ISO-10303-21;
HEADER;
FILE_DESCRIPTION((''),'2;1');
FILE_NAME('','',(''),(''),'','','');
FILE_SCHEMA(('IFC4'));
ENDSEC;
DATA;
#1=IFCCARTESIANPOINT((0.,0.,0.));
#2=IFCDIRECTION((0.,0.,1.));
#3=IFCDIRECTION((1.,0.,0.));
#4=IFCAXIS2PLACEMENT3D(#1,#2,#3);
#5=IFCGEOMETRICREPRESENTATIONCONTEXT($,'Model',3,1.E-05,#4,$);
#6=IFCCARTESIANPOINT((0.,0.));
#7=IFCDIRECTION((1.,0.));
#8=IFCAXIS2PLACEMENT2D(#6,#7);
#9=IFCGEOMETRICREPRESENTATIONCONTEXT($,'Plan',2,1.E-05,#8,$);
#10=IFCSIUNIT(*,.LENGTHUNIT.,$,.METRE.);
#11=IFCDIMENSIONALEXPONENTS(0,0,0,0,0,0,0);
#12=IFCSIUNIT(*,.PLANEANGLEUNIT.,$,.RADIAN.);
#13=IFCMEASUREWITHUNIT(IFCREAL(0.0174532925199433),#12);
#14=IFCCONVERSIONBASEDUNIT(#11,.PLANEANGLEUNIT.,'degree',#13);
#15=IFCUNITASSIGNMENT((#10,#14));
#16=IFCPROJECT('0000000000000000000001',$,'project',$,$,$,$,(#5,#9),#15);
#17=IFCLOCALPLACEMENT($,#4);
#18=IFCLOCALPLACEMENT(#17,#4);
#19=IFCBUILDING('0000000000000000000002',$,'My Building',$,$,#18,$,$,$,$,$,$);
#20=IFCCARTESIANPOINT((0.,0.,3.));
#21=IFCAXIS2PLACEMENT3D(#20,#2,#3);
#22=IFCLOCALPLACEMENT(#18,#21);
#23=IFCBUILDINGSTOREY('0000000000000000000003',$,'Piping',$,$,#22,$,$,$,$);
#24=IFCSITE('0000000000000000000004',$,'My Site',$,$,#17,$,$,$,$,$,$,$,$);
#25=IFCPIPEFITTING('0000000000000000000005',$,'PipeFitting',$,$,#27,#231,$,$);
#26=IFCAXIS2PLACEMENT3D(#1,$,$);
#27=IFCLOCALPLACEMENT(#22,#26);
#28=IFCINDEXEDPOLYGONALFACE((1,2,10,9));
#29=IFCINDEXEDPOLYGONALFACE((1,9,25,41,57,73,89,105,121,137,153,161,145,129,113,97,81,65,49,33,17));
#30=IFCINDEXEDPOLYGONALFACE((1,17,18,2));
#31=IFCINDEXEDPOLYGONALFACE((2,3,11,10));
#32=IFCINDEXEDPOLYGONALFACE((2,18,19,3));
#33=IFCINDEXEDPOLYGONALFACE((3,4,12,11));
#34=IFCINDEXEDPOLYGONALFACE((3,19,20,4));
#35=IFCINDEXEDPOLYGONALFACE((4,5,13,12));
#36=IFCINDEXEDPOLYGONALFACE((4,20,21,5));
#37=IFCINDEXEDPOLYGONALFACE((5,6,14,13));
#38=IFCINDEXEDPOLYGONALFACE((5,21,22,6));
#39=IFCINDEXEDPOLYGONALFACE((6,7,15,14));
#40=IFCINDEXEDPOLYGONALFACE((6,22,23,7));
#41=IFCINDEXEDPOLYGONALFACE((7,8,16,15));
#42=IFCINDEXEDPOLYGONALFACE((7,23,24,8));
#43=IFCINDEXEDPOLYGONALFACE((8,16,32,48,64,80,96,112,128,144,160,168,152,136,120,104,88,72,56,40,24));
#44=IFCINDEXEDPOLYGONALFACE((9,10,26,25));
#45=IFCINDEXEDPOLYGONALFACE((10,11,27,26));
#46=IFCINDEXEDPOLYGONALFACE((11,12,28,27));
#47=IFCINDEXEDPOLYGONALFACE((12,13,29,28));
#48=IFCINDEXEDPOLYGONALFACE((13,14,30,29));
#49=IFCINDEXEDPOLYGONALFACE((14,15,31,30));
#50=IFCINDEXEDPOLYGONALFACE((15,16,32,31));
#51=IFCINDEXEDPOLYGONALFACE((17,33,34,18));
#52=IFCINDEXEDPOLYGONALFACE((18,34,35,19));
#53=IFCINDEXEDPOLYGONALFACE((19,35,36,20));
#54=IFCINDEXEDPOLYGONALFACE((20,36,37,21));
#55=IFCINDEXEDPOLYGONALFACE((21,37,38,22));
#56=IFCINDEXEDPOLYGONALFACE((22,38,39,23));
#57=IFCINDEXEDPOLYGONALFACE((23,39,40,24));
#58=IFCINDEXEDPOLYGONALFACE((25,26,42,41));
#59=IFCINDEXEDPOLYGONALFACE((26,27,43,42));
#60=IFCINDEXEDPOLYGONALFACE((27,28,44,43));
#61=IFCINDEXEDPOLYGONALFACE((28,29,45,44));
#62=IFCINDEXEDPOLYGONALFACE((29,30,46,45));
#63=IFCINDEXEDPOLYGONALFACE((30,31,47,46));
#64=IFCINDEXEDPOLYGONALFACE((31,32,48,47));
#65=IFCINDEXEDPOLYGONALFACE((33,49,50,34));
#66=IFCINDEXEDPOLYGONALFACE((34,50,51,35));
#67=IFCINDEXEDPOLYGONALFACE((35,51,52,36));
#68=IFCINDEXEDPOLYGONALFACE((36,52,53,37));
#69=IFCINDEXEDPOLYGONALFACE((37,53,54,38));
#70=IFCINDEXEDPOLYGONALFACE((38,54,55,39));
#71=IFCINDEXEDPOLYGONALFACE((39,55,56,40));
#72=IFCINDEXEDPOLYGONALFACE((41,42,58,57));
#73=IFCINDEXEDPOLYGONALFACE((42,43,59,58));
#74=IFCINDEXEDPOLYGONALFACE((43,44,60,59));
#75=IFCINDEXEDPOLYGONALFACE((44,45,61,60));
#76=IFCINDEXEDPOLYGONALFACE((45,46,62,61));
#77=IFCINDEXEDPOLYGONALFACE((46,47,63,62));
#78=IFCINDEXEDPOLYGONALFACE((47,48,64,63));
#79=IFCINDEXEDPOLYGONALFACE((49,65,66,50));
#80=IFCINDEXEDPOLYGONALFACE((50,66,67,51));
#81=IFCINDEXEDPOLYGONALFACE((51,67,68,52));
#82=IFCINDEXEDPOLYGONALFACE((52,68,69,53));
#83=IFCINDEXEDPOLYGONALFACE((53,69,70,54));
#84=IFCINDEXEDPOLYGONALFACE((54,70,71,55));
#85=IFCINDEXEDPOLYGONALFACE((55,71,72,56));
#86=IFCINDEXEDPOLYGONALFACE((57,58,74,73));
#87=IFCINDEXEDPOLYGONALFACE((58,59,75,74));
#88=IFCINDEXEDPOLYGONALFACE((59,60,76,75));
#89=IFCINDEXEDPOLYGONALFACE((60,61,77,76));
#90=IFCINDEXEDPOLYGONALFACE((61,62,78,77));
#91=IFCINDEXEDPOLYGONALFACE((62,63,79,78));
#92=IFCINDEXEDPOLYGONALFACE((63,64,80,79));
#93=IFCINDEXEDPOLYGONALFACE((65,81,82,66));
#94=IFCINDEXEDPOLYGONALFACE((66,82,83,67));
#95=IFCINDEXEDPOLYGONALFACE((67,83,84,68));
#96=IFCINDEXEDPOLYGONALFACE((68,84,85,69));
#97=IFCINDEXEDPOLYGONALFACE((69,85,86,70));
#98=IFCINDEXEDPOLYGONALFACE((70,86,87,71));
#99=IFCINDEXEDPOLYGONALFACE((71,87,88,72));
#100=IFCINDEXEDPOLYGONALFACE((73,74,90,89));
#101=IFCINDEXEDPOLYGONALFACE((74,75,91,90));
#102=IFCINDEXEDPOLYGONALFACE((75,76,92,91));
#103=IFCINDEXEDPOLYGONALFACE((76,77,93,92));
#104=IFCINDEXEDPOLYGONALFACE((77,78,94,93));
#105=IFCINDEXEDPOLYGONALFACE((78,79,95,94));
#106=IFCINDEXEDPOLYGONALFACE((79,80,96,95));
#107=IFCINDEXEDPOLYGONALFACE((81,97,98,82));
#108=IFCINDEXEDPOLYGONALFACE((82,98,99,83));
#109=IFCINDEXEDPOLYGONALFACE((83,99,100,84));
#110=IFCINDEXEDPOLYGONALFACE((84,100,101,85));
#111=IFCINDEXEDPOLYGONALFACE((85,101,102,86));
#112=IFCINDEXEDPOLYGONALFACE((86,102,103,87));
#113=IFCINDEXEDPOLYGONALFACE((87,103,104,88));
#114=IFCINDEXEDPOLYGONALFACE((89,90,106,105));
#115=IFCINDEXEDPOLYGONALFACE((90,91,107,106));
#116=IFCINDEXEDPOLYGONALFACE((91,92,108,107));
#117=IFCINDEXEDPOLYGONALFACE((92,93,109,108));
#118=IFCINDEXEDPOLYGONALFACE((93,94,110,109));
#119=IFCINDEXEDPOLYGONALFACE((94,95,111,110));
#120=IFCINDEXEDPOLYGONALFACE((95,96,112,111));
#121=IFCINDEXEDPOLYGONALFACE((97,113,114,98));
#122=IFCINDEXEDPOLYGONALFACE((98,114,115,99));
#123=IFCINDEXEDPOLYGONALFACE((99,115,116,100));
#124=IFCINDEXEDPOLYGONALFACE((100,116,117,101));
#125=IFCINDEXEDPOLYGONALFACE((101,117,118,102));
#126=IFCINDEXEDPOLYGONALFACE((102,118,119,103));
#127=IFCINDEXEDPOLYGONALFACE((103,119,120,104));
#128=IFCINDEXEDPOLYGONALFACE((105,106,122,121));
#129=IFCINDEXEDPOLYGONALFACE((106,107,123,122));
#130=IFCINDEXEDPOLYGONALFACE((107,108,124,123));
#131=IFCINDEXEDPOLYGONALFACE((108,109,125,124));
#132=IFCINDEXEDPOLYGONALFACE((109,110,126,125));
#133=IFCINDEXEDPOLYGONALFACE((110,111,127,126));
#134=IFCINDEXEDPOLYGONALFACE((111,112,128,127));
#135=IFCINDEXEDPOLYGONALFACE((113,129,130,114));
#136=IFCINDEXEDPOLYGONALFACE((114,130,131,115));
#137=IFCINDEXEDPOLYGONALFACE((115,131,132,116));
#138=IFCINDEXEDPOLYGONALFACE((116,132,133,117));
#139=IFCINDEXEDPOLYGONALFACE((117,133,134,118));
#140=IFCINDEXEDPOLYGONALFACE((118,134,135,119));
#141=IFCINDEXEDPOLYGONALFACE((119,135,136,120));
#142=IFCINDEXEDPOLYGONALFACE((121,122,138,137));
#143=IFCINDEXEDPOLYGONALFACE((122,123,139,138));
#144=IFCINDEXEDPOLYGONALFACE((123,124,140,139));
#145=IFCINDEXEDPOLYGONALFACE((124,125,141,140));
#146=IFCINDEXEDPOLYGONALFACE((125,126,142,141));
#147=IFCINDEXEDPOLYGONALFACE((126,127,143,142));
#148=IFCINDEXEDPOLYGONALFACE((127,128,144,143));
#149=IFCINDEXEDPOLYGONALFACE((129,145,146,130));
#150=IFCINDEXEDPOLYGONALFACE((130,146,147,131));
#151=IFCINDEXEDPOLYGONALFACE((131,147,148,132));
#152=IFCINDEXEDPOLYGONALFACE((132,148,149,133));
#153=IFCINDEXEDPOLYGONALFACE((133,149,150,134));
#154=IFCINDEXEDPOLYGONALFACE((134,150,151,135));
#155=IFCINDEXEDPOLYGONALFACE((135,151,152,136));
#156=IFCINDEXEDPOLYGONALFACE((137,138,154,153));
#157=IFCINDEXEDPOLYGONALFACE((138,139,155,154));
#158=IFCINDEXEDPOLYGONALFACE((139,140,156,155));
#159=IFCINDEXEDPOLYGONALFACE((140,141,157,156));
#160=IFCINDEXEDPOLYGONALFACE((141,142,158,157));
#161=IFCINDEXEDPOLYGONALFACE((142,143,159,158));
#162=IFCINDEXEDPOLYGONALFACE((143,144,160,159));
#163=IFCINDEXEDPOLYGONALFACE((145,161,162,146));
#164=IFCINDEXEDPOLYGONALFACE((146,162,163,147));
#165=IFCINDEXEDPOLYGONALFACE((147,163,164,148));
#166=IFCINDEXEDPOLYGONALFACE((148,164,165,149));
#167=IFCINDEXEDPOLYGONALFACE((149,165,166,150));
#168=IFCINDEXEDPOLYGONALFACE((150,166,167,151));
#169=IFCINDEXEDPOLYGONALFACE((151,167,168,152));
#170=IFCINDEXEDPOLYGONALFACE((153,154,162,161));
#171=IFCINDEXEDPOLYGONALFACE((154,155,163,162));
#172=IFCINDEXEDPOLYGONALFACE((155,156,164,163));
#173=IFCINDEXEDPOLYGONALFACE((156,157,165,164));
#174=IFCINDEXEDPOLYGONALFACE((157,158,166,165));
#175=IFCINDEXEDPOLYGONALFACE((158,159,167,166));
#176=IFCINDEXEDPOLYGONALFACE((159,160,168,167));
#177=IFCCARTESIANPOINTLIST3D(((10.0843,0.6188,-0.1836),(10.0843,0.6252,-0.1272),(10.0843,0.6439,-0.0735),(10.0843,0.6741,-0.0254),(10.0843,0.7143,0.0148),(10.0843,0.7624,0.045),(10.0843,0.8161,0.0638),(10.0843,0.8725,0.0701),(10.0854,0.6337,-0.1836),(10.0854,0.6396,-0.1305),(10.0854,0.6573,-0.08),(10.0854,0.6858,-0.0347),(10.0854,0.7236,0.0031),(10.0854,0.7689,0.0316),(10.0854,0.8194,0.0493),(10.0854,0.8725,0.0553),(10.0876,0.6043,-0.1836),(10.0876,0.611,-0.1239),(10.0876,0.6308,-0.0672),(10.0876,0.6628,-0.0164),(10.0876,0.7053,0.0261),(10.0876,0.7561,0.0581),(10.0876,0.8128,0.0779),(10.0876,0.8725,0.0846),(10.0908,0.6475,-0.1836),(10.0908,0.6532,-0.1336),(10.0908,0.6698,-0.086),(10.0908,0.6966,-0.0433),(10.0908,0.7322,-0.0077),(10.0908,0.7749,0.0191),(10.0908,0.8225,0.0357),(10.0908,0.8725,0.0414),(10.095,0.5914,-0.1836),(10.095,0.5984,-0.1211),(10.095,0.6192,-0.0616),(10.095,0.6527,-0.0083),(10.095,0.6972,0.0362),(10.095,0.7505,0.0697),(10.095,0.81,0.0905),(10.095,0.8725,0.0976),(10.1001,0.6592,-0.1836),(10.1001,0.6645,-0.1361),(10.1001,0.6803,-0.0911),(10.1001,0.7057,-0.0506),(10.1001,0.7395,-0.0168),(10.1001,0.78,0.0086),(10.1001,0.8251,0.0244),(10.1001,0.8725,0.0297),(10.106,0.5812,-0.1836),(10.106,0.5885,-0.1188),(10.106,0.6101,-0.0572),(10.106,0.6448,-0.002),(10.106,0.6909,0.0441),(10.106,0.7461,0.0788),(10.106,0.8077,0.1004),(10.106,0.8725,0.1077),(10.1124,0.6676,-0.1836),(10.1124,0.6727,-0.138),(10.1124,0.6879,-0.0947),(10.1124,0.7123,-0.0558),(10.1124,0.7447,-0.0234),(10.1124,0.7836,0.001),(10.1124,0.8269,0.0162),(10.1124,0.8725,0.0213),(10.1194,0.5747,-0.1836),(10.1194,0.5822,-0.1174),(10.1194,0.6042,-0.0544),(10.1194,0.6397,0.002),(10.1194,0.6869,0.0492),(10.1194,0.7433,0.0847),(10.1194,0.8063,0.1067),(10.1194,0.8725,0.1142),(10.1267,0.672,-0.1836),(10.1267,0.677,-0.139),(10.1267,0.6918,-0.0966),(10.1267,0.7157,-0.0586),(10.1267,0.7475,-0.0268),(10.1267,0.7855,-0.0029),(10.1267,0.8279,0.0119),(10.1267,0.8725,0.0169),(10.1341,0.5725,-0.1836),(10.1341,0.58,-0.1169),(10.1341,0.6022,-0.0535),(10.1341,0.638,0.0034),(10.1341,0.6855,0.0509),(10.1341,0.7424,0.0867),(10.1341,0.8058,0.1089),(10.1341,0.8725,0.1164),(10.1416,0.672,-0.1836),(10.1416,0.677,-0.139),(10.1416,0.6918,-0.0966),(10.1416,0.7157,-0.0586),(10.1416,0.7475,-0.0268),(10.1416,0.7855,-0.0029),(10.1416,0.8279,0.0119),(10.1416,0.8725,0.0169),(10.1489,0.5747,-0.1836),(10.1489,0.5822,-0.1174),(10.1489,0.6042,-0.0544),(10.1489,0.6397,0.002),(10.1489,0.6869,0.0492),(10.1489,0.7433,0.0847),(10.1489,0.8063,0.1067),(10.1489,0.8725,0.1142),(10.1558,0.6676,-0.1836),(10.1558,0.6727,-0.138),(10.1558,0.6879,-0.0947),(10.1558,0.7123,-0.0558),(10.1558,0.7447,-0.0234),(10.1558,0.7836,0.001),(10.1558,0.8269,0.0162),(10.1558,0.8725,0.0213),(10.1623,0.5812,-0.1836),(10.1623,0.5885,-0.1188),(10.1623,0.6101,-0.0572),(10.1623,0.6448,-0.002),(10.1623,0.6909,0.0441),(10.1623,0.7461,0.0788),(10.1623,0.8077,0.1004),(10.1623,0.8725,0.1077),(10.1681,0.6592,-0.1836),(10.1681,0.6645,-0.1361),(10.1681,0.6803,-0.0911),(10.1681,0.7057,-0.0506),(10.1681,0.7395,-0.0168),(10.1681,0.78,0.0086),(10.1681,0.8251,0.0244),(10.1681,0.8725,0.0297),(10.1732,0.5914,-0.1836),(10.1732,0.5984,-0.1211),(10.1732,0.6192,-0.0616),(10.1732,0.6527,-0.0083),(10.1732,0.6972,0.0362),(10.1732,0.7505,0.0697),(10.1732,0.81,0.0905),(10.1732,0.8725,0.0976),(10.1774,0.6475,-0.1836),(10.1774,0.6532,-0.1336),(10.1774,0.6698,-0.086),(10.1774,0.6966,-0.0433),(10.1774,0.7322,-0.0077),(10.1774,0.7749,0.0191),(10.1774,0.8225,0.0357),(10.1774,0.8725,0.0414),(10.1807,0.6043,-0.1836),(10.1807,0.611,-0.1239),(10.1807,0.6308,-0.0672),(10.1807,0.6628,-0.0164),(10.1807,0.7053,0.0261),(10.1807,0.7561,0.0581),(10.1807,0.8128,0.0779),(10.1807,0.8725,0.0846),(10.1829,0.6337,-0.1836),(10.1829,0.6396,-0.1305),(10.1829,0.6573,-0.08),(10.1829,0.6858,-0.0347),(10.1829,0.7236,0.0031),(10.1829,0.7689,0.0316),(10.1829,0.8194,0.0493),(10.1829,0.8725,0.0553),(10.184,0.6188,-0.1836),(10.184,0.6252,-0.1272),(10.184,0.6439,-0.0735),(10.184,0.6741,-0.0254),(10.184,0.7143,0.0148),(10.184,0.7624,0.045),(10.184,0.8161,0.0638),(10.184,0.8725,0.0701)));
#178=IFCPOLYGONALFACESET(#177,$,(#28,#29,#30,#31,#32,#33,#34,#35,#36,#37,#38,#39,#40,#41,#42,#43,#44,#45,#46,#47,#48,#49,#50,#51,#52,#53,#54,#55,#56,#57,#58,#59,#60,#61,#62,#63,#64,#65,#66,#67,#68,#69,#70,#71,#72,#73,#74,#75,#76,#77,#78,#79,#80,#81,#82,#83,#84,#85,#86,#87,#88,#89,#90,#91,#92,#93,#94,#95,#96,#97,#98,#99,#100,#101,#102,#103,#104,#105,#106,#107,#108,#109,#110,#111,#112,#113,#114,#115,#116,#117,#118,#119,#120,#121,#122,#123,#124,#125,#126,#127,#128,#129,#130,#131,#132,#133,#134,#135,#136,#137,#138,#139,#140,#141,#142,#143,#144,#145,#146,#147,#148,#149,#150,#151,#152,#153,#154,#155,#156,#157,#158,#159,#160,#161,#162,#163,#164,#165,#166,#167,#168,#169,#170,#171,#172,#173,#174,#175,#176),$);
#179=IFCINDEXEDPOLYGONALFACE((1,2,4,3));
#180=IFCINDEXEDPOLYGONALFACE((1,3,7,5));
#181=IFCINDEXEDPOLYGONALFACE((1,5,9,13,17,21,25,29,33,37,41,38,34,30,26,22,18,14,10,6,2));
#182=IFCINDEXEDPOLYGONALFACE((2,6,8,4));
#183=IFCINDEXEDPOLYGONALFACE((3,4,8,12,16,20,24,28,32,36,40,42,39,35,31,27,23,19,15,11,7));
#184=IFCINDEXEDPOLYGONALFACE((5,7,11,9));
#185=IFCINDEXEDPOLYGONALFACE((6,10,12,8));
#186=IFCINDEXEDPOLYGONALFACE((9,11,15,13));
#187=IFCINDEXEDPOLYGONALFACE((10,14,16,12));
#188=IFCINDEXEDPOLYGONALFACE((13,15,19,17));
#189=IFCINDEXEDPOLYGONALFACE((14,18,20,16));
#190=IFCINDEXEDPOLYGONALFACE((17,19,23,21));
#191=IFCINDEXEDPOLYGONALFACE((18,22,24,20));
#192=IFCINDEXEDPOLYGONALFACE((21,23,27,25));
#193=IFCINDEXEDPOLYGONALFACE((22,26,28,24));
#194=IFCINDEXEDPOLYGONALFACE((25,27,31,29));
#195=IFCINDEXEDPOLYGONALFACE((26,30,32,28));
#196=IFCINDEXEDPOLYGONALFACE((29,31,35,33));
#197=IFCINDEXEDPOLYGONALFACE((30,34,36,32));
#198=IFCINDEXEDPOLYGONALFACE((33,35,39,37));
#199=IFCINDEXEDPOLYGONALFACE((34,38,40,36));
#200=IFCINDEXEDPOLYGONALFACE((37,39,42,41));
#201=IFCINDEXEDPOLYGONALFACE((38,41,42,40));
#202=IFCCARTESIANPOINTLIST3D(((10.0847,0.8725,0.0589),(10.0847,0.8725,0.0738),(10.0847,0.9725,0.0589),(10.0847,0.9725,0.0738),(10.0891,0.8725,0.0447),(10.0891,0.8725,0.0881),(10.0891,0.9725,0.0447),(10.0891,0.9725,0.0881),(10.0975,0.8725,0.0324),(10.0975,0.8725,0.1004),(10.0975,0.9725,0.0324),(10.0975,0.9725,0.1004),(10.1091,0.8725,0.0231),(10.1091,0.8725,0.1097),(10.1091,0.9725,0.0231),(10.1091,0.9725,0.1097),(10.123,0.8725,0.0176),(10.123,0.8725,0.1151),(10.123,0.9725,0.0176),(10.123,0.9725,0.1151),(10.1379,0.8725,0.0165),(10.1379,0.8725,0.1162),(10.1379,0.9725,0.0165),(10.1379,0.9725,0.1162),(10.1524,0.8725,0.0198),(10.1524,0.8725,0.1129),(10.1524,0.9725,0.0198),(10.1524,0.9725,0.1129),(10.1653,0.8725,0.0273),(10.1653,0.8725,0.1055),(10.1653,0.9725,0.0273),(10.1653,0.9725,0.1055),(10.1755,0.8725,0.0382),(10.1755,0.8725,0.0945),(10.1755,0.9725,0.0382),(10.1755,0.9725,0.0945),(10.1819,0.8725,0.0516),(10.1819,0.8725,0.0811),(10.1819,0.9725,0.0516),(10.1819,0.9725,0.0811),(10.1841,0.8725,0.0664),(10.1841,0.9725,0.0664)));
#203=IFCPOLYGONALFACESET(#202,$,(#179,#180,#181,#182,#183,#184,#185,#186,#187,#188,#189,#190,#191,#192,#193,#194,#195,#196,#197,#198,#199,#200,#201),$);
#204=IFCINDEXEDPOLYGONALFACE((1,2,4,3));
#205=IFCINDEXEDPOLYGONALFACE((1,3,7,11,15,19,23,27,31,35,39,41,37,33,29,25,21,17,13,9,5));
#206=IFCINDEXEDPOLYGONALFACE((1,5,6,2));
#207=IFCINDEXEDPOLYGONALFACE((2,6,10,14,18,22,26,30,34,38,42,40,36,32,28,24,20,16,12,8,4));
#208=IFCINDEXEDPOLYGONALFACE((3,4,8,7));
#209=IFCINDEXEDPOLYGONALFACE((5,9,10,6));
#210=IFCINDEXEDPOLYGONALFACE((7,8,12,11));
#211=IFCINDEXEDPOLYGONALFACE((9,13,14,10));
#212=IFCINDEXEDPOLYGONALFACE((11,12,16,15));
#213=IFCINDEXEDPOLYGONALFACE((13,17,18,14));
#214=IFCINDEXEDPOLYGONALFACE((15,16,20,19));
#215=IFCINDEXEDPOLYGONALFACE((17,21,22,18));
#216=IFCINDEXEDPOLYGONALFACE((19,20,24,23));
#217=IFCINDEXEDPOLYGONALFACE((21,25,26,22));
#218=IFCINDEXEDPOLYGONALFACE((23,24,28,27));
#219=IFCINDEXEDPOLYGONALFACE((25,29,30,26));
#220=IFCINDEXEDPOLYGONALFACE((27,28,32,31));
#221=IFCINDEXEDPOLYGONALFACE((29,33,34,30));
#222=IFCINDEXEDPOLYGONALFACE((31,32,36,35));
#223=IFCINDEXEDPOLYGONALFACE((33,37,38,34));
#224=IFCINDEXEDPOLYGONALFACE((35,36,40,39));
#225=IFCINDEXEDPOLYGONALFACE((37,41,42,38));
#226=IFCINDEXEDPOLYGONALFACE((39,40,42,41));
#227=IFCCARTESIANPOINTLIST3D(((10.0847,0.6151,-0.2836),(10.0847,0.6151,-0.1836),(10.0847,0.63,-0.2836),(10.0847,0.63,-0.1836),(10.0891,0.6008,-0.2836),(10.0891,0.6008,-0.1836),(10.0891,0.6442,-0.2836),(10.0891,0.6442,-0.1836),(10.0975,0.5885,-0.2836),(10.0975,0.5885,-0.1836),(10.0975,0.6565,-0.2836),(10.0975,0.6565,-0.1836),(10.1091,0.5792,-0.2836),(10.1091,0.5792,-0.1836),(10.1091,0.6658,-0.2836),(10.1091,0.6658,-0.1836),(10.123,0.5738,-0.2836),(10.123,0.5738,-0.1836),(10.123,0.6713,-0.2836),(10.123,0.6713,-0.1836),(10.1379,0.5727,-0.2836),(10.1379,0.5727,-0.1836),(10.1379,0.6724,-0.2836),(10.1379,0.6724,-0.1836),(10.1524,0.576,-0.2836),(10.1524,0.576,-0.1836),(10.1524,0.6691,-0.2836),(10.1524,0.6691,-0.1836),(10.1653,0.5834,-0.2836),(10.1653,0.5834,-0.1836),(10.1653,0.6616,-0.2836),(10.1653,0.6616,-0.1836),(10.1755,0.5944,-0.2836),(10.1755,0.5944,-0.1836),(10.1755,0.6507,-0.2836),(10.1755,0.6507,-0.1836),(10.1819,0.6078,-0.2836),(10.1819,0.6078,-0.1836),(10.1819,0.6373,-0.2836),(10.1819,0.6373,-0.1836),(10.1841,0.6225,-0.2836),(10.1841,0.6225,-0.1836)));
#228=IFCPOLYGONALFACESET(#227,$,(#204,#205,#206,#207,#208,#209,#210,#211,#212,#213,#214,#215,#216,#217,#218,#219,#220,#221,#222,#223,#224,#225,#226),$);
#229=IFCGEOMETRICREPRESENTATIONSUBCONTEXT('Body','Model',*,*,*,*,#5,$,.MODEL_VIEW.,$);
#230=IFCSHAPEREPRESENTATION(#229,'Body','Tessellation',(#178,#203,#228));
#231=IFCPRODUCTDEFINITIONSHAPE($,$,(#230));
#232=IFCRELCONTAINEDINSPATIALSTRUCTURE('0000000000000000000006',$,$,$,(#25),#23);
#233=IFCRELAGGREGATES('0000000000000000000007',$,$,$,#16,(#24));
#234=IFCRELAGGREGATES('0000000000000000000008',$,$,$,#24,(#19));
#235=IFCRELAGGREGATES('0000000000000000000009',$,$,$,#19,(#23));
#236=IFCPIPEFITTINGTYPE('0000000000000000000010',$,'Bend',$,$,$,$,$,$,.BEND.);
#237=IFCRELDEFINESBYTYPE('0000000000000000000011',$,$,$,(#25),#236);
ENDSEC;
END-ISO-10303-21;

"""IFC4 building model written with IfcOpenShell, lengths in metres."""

from ifc_helpers import new_model, entity, si_unit, converted_unit, frame, origin_with_axes, origin_2d_with_axis, place, context, subcontext, project, spatial, circle, extrude, source, transform, mapped, type_object, type_shapes, element, save


model = new_model("IFC4")

# Units and contexts
model_context = context("Model", 3, precision=1e-05, world=origin_with_axes())
plan_context = context("Plan", 2, precision=1e-05, world=origin_2d_with_axis())
body_context = subcontext(model_context, "Body", "Model", "MODEL_VIEW")
ifc_project = project(units=[si_unit("LENGTHUNIT", "METRE"), converted_unit("PLANEANGLEUNIT", "degree", entity("IfcReal", 0.0174532925199433), si_unit("PLANEANGLEUNIT", "RADIAN"), dimensions=[0, 0, 0, 0, 0, 0, 0])], contexts=[model_context, plan_context])

# Site, building, storey
site_placement = place(None, origin_with_axes())
site = spatial("IfcSite", under=ifc_project, at=site_placement, Name="My Site")
building_placement = place(site_placement, origin_with_axes())
building = spatial("IfcBuilding", under=site, at=building_placement, Name="My Building")
storey_placement = place(building_placement, frame((0.0, 0.0, 3.0), z_axis=(0.0, 0.0, 1.0), x_axis=(1.0, 0.0, 0.0)))
storey = spatial("IfcBuildingStorey", under=building, at=storey_placement, Name="Piping")

# Pipe fitting
pipe_fitting_type_1 = type_object("IfcPipeFittingType", Name="Bend", PredefinedType="BEND")
shared_shape = source(origin_with_axes(), body_context, "Body", "SolidModel", [
    entity("IfcSweptDiskSolid", entity("IfcIndexedPolyCurve", entity("IfcCartesianPointList3D", [[0.0, 0.0, 0.1], [0.0, -0.0732, 0.2768], [0.0, -0.25, 0.35]]), [entity("IfcArcIndex", [1, 2, 3])]), 0.05),
    extrude(circle(Radius=0.05), origin_with_axes(), (0.0, 0.0, 1.0), 0.1),
    extrude(circle(Radius=0.05), frame((0.0, -0.25, 0.35), z_axis=(0.0, -1.0, -0.000002), x_axis=(1.0, 0.0, 0.0)), (0.0, 0.0, 1.0), 0.1),
])
type_shapes(pipe_fitting_type_1, [shared_shape])
for number, where, z_axis, x_axis, name in (
    (1, (10.1341, 0.9725, 0.0664), (0.0, -1.0, 0.000002), (1.0, 0.0, 0.0), "PipeFitting"),
):
    element("IfcPipeFitting", number, at=place(storey_placement, frame(where, z_axis=z_axis, x_axis=x_axis)), inside=storey, type_object=pipe_fitting_type_1, Name=name, context=body_context, shape_type="MappedRepresentation", body=[
        mapped(shared_shape, transform((0.0, 0.0, 0.0), x_axis=(1.0, 0.0, 0.0), y_axis=(0.0, 1.0, 0.0), z_axis=(0.0, 0.0, 1.0), scale=1.0)),
    ])

save(model, "model.ifc")
